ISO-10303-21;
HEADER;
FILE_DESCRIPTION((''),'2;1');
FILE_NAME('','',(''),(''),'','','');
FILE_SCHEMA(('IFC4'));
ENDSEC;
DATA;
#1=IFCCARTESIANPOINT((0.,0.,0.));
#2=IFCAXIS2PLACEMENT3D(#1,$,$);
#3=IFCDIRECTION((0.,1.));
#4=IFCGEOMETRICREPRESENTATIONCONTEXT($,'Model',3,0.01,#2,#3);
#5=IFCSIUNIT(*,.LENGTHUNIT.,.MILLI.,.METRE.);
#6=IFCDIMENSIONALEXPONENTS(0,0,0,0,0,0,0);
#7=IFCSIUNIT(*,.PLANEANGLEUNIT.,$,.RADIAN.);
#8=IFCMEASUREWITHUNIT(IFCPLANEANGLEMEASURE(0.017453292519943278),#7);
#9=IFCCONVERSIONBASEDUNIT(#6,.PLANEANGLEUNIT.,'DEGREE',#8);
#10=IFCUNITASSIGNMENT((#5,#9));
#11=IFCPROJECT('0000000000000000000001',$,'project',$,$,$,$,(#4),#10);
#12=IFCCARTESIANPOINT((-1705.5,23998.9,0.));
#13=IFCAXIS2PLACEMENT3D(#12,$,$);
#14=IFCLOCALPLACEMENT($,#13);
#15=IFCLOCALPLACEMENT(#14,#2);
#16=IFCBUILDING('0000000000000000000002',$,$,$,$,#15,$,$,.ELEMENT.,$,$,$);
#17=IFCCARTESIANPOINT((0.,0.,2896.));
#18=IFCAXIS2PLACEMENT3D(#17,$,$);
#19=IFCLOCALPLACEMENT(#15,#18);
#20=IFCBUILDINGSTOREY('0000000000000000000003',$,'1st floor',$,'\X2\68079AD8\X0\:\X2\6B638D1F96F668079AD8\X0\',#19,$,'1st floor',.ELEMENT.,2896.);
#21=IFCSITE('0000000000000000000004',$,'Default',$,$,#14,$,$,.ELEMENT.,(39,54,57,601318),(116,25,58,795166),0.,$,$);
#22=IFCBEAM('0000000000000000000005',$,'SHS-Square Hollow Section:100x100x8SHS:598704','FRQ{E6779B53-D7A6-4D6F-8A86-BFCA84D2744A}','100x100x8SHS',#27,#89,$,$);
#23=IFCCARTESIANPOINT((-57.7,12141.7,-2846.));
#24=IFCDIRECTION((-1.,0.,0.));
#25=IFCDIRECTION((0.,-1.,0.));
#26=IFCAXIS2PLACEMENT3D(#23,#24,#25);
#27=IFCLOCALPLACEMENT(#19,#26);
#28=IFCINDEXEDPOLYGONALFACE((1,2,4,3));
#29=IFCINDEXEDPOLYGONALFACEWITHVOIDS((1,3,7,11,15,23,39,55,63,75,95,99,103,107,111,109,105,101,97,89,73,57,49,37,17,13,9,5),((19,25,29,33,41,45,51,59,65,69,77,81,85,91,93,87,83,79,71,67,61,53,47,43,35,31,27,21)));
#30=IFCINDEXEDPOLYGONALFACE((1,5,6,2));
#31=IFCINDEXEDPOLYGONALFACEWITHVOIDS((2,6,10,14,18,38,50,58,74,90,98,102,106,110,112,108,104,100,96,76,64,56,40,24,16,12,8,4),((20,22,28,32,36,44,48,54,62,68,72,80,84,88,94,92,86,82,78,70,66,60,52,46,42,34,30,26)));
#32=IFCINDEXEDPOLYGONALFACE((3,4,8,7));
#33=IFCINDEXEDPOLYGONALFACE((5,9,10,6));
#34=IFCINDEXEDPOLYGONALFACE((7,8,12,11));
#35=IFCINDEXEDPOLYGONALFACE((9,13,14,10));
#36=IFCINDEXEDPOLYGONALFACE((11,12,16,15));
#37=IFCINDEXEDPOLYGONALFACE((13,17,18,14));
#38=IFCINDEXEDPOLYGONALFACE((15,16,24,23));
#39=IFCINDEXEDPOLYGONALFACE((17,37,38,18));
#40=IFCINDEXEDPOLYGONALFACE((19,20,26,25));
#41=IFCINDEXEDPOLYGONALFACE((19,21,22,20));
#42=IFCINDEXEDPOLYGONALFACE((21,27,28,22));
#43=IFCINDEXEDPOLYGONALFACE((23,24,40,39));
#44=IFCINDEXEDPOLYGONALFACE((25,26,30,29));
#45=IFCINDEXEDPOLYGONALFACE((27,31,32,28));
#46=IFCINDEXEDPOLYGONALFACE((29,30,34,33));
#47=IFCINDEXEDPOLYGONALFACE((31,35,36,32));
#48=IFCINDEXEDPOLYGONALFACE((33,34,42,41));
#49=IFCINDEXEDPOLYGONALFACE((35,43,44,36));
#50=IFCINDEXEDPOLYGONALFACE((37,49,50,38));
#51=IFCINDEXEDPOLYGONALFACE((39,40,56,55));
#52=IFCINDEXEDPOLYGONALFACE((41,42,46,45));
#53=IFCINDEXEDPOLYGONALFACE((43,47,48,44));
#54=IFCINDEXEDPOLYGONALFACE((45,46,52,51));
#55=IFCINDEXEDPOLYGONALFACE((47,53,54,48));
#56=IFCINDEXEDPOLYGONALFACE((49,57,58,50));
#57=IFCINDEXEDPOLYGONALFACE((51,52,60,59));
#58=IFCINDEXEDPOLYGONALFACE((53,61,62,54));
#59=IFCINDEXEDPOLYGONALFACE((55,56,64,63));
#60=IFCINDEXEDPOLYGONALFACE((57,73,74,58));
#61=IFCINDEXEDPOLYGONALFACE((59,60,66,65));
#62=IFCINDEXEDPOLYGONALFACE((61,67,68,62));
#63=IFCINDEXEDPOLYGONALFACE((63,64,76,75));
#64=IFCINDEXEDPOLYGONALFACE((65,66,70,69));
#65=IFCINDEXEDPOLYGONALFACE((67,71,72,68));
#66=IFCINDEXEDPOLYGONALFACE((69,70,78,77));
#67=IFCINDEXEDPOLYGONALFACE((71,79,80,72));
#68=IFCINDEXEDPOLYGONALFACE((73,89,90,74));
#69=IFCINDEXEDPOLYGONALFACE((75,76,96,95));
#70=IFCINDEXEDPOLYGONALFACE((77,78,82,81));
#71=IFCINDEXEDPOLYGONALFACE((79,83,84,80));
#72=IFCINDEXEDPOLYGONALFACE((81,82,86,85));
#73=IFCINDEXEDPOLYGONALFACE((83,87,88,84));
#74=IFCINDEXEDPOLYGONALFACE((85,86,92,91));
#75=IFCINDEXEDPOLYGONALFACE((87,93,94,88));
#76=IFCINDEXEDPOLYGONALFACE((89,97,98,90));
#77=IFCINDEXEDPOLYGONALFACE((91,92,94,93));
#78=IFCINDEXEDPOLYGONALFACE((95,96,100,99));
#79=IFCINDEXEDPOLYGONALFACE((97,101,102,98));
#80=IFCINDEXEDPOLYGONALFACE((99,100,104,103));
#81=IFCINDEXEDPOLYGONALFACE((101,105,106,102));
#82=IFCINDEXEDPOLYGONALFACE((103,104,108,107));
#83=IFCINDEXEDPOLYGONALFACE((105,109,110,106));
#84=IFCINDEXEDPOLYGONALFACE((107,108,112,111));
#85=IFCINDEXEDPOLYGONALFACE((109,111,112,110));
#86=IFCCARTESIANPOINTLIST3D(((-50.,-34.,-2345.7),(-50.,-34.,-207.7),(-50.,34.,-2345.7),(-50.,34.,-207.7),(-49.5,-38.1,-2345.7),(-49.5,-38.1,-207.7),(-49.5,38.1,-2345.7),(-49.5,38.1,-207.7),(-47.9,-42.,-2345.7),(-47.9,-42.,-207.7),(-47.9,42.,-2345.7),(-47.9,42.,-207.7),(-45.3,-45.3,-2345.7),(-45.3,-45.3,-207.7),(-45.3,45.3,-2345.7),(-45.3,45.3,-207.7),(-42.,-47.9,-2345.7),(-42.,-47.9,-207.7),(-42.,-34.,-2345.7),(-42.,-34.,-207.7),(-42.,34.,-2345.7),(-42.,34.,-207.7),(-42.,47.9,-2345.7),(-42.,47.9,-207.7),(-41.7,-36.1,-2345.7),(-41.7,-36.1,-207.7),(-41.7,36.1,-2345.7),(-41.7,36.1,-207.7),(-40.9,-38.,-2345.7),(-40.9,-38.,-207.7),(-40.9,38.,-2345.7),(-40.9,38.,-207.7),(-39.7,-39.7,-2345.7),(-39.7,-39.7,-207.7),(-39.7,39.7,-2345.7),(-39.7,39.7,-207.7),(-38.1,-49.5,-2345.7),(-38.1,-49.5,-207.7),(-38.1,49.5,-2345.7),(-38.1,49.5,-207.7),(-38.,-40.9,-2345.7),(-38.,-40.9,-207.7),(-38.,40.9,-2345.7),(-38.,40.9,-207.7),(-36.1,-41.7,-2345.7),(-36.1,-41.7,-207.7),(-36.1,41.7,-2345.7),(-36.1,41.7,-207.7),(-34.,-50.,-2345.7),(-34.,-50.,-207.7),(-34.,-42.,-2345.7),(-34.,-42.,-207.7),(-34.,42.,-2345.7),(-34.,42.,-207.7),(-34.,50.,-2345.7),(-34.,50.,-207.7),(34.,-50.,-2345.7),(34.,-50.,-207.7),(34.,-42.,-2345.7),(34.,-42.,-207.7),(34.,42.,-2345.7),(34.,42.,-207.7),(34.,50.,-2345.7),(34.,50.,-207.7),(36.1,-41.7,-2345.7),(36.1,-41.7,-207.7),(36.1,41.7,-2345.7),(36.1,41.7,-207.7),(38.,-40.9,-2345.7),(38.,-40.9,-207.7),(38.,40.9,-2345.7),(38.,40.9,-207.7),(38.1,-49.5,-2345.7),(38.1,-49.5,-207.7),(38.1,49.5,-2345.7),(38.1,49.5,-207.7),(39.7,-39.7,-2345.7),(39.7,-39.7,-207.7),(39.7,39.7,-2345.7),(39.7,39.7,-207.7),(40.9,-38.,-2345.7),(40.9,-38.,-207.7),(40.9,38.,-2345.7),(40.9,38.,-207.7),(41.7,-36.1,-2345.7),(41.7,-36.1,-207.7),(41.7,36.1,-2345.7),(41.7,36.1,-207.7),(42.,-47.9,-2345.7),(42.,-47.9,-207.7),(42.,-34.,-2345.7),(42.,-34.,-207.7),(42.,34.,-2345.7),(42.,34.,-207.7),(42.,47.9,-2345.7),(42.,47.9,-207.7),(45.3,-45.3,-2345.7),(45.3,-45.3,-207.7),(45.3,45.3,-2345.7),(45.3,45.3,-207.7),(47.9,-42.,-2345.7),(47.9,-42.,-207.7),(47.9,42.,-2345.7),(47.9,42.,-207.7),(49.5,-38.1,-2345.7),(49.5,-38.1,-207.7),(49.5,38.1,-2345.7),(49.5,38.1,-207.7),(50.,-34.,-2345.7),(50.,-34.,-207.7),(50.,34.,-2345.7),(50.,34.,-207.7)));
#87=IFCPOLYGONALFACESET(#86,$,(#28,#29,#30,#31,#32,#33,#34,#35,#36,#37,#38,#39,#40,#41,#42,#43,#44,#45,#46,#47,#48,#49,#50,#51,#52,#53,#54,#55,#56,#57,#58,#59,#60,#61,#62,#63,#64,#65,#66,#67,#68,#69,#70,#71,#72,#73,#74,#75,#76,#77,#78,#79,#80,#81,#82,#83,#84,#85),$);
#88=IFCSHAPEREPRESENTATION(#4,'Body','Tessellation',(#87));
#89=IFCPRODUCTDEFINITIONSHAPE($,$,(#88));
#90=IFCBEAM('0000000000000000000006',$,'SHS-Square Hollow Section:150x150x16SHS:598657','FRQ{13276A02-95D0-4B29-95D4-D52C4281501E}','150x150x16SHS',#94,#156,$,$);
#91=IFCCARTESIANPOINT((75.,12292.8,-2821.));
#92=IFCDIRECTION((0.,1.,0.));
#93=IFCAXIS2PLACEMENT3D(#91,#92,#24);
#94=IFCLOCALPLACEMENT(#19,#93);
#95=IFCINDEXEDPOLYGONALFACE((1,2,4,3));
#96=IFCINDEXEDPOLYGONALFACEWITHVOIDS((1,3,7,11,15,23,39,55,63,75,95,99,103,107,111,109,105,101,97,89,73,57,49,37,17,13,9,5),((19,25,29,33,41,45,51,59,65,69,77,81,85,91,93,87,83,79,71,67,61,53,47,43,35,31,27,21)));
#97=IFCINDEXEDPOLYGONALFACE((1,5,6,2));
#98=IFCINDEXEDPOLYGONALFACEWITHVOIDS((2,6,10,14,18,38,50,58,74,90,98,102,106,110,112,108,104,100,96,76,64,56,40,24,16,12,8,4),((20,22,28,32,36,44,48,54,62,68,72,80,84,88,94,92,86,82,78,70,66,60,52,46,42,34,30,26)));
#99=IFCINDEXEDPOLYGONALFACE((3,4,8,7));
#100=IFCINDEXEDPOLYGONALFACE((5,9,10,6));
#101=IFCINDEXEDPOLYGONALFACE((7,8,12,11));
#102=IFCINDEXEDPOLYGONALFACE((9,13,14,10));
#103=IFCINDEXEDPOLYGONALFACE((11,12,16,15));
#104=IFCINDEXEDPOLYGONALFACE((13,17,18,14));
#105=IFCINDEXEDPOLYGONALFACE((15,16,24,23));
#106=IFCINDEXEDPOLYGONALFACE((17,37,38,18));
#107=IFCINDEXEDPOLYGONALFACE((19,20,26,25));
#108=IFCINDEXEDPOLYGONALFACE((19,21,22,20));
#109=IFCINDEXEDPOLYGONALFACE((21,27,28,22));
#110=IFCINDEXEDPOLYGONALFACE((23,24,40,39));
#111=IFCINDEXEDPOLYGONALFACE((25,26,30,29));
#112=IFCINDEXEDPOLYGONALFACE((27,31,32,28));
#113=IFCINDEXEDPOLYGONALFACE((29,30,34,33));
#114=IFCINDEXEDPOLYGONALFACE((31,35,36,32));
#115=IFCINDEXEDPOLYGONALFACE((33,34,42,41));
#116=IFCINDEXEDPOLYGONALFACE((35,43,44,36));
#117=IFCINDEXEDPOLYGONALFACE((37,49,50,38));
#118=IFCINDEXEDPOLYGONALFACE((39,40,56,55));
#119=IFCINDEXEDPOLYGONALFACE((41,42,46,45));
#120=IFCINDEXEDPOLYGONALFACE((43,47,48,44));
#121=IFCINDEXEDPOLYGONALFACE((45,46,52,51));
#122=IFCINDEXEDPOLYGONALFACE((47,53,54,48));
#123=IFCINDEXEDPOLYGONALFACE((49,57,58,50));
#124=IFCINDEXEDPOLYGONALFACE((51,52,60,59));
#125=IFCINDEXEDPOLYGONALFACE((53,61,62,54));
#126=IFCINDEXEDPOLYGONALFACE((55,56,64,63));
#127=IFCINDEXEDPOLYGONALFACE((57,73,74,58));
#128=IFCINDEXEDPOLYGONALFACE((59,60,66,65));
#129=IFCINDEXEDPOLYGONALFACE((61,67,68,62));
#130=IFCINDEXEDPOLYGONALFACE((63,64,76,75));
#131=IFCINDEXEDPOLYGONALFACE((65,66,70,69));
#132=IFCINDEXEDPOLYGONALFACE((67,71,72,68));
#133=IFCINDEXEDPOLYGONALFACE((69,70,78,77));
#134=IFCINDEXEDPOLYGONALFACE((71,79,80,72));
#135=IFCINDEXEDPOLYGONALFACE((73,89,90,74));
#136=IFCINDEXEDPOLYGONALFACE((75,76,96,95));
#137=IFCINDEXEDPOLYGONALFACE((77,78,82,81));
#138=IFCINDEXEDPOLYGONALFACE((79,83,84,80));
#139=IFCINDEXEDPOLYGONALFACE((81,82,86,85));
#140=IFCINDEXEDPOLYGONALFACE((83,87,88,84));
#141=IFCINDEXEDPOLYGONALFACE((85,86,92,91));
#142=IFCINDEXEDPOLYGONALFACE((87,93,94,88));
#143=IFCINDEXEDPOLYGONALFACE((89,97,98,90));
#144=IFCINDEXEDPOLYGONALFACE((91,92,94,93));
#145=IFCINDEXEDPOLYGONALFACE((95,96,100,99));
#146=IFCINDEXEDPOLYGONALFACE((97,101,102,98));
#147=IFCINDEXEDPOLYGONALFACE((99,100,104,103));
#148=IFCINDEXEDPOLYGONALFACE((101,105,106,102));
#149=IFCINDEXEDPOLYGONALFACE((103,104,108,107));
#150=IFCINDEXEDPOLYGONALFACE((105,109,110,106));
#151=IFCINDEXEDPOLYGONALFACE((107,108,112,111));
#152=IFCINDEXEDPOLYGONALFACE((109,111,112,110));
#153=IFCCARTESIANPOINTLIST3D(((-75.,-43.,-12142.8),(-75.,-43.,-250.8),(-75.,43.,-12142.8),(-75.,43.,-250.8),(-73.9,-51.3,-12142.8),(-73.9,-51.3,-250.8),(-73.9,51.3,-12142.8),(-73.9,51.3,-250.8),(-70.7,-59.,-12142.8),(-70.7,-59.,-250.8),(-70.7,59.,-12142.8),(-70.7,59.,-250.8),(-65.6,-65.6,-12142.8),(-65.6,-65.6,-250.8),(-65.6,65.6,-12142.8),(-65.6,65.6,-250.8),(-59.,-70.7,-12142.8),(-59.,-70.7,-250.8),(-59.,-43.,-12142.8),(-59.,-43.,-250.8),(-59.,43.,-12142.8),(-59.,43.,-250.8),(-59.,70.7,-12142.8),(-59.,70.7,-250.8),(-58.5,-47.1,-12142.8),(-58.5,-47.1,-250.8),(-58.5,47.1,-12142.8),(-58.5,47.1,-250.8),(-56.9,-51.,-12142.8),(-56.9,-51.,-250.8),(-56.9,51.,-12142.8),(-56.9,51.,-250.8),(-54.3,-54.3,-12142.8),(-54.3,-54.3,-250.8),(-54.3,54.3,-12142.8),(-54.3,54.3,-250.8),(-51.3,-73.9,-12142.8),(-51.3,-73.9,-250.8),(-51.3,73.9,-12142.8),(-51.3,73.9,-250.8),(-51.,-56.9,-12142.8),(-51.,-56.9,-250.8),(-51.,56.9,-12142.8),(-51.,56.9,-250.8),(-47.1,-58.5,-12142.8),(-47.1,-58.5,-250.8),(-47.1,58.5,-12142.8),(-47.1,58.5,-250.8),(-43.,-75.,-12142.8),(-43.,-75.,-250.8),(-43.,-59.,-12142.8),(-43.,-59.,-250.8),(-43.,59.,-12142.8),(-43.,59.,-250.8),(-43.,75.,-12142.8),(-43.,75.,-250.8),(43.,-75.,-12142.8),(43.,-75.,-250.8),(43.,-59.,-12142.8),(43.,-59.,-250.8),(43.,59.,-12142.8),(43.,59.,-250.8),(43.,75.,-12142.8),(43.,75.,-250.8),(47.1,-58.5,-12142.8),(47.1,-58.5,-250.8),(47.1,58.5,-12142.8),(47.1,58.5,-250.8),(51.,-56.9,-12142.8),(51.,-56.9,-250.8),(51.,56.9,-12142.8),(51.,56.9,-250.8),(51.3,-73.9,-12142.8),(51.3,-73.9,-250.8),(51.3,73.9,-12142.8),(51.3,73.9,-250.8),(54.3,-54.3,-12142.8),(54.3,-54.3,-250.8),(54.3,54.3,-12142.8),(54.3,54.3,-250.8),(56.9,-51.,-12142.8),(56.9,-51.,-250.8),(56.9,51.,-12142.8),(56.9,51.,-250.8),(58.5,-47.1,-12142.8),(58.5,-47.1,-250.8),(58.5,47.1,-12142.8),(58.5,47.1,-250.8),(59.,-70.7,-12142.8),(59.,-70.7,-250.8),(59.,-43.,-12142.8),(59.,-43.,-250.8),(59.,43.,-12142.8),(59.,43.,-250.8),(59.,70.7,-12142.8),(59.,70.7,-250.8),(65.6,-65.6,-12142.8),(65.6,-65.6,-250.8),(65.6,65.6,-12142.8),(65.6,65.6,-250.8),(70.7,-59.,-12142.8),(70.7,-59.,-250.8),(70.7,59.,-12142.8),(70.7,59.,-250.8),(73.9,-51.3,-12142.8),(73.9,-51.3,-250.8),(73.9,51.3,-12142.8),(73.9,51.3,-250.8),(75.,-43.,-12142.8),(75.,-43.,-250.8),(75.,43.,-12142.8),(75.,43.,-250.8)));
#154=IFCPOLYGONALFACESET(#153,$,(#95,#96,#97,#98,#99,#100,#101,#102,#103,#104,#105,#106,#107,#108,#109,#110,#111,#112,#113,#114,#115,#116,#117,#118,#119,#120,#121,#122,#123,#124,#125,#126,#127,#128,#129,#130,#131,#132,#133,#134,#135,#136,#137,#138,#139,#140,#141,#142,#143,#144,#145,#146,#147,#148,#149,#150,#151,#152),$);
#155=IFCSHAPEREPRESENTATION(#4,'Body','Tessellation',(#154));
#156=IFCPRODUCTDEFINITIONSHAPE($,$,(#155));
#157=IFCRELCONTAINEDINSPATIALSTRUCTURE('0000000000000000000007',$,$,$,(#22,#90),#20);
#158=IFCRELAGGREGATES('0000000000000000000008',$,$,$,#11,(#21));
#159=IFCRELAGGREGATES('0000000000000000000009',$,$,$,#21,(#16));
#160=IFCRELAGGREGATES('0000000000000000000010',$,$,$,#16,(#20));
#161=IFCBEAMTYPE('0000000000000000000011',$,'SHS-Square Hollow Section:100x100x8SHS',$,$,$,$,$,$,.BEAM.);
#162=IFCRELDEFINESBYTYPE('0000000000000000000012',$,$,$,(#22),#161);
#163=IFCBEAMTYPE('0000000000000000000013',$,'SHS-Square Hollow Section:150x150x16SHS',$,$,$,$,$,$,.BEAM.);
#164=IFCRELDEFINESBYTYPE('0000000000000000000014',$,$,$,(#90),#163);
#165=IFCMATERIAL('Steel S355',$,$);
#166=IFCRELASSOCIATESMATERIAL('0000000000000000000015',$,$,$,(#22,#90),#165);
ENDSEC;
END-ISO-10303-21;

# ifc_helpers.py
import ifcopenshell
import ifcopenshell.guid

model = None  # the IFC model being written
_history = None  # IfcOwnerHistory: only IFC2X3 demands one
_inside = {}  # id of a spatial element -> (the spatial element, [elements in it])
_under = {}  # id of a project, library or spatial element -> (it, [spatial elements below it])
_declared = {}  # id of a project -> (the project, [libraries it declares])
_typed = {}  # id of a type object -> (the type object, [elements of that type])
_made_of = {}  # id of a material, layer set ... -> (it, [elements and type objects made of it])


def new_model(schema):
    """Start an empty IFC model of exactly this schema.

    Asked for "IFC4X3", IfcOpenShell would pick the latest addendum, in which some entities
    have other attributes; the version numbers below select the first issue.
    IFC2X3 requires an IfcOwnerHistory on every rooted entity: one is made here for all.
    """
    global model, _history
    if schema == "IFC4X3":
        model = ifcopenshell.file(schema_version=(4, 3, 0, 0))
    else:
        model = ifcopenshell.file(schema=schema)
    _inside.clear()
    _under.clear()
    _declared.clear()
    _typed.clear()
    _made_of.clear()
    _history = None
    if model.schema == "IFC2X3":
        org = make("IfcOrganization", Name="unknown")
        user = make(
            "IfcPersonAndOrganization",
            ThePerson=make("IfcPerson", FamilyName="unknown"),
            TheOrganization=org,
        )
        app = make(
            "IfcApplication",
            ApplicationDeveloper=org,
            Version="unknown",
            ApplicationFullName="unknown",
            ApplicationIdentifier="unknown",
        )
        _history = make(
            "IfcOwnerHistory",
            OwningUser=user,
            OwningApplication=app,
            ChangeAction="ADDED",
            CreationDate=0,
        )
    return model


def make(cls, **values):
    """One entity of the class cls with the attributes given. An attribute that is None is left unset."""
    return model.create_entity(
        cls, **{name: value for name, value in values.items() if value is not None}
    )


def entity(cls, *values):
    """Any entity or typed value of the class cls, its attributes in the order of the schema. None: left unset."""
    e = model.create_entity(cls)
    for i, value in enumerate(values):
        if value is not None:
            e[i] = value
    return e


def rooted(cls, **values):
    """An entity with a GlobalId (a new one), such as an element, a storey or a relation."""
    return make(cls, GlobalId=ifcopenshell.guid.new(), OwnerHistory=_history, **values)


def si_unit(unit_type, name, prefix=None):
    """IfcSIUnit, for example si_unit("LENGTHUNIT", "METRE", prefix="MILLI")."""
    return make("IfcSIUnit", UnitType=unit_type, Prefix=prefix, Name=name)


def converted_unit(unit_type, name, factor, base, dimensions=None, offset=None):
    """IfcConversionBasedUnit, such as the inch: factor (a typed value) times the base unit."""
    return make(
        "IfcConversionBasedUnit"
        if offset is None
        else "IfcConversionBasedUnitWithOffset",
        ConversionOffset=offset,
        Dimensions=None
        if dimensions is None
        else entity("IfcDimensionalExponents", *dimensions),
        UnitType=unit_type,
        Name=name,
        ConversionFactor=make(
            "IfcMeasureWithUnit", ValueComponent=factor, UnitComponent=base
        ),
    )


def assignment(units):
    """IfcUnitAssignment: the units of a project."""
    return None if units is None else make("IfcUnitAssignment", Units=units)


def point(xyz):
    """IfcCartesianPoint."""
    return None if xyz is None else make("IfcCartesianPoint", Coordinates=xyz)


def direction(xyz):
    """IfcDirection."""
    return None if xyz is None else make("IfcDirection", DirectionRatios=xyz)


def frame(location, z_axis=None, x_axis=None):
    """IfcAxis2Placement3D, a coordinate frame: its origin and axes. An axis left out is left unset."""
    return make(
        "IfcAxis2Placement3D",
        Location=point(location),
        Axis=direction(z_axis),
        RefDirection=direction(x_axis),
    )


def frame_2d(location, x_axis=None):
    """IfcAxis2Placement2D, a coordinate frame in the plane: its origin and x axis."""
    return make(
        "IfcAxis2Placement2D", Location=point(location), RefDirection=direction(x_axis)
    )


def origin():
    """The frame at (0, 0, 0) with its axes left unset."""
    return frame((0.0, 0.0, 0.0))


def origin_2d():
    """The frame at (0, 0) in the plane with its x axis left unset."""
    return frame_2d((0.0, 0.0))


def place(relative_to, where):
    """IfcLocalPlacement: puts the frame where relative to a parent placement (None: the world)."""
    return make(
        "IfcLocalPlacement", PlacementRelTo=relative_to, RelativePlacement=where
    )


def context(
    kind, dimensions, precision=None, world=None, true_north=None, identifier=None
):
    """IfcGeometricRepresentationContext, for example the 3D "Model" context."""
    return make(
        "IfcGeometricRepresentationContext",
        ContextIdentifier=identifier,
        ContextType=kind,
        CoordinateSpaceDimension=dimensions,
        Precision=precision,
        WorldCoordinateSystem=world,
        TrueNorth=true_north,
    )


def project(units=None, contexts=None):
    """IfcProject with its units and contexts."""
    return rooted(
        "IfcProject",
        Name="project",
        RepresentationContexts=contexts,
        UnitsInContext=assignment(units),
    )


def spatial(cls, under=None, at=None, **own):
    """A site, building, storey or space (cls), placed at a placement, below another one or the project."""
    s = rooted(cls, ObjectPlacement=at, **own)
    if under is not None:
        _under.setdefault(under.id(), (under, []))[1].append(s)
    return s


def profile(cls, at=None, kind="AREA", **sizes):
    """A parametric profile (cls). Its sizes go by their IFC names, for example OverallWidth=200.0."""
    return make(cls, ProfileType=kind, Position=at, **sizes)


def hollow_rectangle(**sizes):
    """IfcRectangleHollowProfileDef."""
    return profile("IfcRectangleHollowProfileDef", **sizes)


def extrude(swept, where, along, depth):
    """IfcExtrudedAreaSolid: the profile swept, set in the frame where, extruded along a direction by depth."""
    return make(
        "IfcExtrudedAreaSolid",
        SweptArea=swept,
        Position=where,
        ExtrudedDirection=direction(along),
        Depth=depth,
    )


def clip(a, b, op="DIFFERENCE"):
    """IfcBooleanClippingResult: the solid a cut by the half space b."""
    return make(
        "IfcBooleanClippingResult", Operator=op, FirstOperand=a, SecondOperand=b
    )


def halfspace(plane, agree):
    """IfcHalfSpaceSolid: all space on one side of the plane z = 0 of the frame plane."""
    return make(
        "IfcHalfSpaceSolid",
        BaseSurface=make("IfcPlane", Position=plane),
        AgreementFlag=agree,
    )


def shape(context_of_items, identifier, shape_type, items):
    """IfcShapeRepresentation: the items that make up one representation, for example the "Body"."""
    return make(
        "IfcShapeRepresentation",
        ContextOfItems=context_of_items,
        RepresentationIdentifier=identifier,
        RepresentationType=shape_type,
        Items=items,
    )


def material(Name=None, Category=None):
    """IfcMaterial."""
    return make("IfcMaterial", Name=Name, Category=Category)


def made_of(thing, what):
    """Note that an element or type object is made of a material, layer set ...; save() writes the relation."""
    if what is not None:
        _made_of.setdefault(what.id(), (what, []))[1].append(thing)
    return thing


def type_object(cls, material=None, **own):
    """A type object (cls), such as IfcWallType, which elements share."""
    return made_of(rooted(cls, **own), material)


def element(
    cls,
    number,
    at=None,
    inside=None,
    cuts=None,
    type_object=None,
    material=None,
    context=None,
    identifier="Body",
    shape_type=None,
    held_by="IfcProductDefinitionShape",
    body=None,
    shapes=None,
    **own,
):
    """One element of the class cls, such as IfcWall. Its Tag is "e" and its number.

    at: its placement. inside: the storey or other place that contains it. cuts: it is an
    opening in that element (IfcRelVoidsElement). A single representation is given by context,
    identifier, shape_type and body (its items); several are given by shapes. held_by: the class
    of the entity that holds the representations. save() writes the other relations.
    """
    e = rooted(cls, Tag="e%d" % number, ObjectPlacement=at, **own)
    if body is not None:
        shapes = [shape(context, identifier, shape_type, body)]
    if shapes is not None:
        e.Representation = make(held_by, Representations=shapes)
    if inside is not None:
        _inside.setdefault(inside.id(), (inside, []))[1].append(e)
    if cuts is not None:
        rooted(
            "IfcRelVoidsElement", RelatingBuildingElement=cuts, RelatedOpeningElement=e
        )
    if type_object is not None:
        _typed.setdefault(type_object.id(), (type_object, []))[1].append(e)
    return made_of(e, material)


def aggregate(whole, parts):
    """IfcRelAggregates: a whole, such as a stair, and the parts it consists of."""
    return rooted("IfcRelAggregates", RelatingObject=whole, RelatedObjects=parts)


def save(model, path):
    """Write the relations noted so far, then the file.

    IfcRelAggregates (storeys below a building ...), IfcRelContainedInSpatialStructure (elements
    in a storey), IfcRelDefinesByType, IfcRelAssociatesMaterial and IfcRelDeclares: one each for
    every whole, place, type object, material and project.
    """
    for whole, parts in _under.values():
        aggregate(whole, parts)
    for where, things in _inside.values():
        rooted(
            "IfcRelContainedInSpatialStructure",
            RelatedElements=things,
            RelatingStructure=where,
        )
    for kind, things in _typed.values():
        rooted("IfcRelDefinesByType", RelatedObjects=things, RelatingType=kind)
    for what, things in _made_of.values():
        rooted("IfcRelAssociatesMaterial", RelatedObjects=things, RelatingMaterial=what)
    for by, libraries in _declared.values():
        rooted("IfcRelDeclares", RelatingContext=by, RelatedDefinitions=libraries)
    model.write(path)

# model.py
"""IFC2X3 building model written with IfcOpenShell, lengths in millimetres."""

from ifc_helpers import new_model, entity, si_unit, converted_unit, direction, frame, origin, origin_2d, place, context, project, spatial, hollow_rectangle, extrude, clip, halfspace, material, type_object, element, save


model = new_model("IFC2X3")

# Units and contexts
model_context = context("Model", 3, precision=0.01, world=origin(), true_north=direction((0.0, 1.0)))
ifc_project = project(units=[si_unit("LENGTHUNIT", "METRE", prefix="MILLI"), converted_unit("PLANEANGLEUNIT", "DEGREE", entity("IfcPlaneAngleMeasure", 0.017453292519943278), si_unit("PLANEANGLEUNIT", "RADIAN"), dimensions=[0, 0, 0, 0, 0, 0, 0])], contexts=[model_context])

# Site, building, storey
site_placement = place(None, frame((-1705.5, 23998.9, 0.0)))
site = spatial("IfcSite", under=ifc_project, at=site_placement, Name="Default", CompositionType="ELEMENT", RefLatitude=(39, 54, 57, 601318), RefLongitude=(116, 25, 58, 795166), RefElevation=0.0)
building_placement = place(site_placement, origin())
building = spatial("IfcBuilding", under=site, at=building_placement, CompositionType="ELEMENT")
storey_placement = place(building_placement, frame((0.0, 0.0, 2896.0)))
storey = spatial("IfcBuildingStorey", under=building, at=storey_placement, Name="1st floor", ObjectType="标高:正负零标高", LongName="1st floor", CompositionType="ELEMENT", Elevation=2896.0)

# Shared definitions
ifc_material_1 = material(Name="Steel S355")

# Beam
beam_type_1 = type_object("IfcBeamType", Name="SHS-Square Hollow Section:100x100x8SHS", PredefinedType="BEAM")
beam_1_placement = place(storey_placement, frame((-57.7, 12141.7, -2846.0), z_axis=(-1.0, 0.0, 0.0), x_axis=(0.0, -1.0, 0.0)))
element("IfcBeam", 1, at=beam_1_placement, inside=storey, type_object=beam_type_1, material=ifc_material_1, Name="SHS-Square Hollow Section:100x100x8SHS:598704", Description="FRQ{E6779B53-D7A6-4D6F-8A86-BFCA84D2744A}", ObjectType="100x100x8SHS", context=model_context, shape_type="Clipping", body=[
    clip(clip(extrude(hollow_rectangle(XDim=100.0, YDim=100.0, WallThickness=8.0, InnerFilletRadius=8.0, OuterFilletRadius=16.0, at=origin_2d()), origin(), (0.0, 0.0, -1.0), 2551.4), halfspace(frame((12141.7, -50.0, -207.7), z_axis=(0.0, 0.0, -1.0), x_axis=(-1.0, 0.0, 0.0)), True)), halfspace(frame((12141.7, -50.0, -2345.7), z_axis=(0.0, 0.0, 1.0), x_axis=(1.0, 0.0, 0.0)), True)),
])

# Shared definitions
beam_type_2 = type_object("IfcBeamType", Name="SHS-Square Hollow Section:150x150x16SHS", PredefinedType="BEAM")

# Beam
beam_2_placement = place(storey_placement, frame((75.0, 12292.8, -2821.0), z_axis=(0.0, 1.0, 0.0), x_axis=(-1.0, 0.0, 0.0)))
element("IfcBeam", 2, at=beam_2_placement, inside=storey, type_object=beam_type_2, material=ifc_material_1, Name="SHS-Square Hollow Section:150x150x16SHS:598657", Description="FRQ{13276A02-95D0-4B29-95D4-D52C4281501E}", ObjectType="150x150x16SHS", context=model_context, shape_type="Clipping", body=[
    clip(clip(extrude(hollow_rectangle(XDim=150.0, YDim=150.0, WallThickness=16.0, InnerFilletRadius=16.0, OuterFilletRadius=32.0, at=origin_2d()), origin(), (0.0, 0.0, -1.0), 12398.9), halfspace(frame((75.0, -75.0, -12142.8), z_axis=(0.0, 0.0, 1.0), x_axis=(1.0, 0.0, 0.0)), True)), halfspace(frame((75.0, -75.0, -250.8), z_axis=(0.0, 0.0, -1.0), x_axis=(-1.0, 0.0, 0.0)), True)),
])

save(model, "model.ifc")
